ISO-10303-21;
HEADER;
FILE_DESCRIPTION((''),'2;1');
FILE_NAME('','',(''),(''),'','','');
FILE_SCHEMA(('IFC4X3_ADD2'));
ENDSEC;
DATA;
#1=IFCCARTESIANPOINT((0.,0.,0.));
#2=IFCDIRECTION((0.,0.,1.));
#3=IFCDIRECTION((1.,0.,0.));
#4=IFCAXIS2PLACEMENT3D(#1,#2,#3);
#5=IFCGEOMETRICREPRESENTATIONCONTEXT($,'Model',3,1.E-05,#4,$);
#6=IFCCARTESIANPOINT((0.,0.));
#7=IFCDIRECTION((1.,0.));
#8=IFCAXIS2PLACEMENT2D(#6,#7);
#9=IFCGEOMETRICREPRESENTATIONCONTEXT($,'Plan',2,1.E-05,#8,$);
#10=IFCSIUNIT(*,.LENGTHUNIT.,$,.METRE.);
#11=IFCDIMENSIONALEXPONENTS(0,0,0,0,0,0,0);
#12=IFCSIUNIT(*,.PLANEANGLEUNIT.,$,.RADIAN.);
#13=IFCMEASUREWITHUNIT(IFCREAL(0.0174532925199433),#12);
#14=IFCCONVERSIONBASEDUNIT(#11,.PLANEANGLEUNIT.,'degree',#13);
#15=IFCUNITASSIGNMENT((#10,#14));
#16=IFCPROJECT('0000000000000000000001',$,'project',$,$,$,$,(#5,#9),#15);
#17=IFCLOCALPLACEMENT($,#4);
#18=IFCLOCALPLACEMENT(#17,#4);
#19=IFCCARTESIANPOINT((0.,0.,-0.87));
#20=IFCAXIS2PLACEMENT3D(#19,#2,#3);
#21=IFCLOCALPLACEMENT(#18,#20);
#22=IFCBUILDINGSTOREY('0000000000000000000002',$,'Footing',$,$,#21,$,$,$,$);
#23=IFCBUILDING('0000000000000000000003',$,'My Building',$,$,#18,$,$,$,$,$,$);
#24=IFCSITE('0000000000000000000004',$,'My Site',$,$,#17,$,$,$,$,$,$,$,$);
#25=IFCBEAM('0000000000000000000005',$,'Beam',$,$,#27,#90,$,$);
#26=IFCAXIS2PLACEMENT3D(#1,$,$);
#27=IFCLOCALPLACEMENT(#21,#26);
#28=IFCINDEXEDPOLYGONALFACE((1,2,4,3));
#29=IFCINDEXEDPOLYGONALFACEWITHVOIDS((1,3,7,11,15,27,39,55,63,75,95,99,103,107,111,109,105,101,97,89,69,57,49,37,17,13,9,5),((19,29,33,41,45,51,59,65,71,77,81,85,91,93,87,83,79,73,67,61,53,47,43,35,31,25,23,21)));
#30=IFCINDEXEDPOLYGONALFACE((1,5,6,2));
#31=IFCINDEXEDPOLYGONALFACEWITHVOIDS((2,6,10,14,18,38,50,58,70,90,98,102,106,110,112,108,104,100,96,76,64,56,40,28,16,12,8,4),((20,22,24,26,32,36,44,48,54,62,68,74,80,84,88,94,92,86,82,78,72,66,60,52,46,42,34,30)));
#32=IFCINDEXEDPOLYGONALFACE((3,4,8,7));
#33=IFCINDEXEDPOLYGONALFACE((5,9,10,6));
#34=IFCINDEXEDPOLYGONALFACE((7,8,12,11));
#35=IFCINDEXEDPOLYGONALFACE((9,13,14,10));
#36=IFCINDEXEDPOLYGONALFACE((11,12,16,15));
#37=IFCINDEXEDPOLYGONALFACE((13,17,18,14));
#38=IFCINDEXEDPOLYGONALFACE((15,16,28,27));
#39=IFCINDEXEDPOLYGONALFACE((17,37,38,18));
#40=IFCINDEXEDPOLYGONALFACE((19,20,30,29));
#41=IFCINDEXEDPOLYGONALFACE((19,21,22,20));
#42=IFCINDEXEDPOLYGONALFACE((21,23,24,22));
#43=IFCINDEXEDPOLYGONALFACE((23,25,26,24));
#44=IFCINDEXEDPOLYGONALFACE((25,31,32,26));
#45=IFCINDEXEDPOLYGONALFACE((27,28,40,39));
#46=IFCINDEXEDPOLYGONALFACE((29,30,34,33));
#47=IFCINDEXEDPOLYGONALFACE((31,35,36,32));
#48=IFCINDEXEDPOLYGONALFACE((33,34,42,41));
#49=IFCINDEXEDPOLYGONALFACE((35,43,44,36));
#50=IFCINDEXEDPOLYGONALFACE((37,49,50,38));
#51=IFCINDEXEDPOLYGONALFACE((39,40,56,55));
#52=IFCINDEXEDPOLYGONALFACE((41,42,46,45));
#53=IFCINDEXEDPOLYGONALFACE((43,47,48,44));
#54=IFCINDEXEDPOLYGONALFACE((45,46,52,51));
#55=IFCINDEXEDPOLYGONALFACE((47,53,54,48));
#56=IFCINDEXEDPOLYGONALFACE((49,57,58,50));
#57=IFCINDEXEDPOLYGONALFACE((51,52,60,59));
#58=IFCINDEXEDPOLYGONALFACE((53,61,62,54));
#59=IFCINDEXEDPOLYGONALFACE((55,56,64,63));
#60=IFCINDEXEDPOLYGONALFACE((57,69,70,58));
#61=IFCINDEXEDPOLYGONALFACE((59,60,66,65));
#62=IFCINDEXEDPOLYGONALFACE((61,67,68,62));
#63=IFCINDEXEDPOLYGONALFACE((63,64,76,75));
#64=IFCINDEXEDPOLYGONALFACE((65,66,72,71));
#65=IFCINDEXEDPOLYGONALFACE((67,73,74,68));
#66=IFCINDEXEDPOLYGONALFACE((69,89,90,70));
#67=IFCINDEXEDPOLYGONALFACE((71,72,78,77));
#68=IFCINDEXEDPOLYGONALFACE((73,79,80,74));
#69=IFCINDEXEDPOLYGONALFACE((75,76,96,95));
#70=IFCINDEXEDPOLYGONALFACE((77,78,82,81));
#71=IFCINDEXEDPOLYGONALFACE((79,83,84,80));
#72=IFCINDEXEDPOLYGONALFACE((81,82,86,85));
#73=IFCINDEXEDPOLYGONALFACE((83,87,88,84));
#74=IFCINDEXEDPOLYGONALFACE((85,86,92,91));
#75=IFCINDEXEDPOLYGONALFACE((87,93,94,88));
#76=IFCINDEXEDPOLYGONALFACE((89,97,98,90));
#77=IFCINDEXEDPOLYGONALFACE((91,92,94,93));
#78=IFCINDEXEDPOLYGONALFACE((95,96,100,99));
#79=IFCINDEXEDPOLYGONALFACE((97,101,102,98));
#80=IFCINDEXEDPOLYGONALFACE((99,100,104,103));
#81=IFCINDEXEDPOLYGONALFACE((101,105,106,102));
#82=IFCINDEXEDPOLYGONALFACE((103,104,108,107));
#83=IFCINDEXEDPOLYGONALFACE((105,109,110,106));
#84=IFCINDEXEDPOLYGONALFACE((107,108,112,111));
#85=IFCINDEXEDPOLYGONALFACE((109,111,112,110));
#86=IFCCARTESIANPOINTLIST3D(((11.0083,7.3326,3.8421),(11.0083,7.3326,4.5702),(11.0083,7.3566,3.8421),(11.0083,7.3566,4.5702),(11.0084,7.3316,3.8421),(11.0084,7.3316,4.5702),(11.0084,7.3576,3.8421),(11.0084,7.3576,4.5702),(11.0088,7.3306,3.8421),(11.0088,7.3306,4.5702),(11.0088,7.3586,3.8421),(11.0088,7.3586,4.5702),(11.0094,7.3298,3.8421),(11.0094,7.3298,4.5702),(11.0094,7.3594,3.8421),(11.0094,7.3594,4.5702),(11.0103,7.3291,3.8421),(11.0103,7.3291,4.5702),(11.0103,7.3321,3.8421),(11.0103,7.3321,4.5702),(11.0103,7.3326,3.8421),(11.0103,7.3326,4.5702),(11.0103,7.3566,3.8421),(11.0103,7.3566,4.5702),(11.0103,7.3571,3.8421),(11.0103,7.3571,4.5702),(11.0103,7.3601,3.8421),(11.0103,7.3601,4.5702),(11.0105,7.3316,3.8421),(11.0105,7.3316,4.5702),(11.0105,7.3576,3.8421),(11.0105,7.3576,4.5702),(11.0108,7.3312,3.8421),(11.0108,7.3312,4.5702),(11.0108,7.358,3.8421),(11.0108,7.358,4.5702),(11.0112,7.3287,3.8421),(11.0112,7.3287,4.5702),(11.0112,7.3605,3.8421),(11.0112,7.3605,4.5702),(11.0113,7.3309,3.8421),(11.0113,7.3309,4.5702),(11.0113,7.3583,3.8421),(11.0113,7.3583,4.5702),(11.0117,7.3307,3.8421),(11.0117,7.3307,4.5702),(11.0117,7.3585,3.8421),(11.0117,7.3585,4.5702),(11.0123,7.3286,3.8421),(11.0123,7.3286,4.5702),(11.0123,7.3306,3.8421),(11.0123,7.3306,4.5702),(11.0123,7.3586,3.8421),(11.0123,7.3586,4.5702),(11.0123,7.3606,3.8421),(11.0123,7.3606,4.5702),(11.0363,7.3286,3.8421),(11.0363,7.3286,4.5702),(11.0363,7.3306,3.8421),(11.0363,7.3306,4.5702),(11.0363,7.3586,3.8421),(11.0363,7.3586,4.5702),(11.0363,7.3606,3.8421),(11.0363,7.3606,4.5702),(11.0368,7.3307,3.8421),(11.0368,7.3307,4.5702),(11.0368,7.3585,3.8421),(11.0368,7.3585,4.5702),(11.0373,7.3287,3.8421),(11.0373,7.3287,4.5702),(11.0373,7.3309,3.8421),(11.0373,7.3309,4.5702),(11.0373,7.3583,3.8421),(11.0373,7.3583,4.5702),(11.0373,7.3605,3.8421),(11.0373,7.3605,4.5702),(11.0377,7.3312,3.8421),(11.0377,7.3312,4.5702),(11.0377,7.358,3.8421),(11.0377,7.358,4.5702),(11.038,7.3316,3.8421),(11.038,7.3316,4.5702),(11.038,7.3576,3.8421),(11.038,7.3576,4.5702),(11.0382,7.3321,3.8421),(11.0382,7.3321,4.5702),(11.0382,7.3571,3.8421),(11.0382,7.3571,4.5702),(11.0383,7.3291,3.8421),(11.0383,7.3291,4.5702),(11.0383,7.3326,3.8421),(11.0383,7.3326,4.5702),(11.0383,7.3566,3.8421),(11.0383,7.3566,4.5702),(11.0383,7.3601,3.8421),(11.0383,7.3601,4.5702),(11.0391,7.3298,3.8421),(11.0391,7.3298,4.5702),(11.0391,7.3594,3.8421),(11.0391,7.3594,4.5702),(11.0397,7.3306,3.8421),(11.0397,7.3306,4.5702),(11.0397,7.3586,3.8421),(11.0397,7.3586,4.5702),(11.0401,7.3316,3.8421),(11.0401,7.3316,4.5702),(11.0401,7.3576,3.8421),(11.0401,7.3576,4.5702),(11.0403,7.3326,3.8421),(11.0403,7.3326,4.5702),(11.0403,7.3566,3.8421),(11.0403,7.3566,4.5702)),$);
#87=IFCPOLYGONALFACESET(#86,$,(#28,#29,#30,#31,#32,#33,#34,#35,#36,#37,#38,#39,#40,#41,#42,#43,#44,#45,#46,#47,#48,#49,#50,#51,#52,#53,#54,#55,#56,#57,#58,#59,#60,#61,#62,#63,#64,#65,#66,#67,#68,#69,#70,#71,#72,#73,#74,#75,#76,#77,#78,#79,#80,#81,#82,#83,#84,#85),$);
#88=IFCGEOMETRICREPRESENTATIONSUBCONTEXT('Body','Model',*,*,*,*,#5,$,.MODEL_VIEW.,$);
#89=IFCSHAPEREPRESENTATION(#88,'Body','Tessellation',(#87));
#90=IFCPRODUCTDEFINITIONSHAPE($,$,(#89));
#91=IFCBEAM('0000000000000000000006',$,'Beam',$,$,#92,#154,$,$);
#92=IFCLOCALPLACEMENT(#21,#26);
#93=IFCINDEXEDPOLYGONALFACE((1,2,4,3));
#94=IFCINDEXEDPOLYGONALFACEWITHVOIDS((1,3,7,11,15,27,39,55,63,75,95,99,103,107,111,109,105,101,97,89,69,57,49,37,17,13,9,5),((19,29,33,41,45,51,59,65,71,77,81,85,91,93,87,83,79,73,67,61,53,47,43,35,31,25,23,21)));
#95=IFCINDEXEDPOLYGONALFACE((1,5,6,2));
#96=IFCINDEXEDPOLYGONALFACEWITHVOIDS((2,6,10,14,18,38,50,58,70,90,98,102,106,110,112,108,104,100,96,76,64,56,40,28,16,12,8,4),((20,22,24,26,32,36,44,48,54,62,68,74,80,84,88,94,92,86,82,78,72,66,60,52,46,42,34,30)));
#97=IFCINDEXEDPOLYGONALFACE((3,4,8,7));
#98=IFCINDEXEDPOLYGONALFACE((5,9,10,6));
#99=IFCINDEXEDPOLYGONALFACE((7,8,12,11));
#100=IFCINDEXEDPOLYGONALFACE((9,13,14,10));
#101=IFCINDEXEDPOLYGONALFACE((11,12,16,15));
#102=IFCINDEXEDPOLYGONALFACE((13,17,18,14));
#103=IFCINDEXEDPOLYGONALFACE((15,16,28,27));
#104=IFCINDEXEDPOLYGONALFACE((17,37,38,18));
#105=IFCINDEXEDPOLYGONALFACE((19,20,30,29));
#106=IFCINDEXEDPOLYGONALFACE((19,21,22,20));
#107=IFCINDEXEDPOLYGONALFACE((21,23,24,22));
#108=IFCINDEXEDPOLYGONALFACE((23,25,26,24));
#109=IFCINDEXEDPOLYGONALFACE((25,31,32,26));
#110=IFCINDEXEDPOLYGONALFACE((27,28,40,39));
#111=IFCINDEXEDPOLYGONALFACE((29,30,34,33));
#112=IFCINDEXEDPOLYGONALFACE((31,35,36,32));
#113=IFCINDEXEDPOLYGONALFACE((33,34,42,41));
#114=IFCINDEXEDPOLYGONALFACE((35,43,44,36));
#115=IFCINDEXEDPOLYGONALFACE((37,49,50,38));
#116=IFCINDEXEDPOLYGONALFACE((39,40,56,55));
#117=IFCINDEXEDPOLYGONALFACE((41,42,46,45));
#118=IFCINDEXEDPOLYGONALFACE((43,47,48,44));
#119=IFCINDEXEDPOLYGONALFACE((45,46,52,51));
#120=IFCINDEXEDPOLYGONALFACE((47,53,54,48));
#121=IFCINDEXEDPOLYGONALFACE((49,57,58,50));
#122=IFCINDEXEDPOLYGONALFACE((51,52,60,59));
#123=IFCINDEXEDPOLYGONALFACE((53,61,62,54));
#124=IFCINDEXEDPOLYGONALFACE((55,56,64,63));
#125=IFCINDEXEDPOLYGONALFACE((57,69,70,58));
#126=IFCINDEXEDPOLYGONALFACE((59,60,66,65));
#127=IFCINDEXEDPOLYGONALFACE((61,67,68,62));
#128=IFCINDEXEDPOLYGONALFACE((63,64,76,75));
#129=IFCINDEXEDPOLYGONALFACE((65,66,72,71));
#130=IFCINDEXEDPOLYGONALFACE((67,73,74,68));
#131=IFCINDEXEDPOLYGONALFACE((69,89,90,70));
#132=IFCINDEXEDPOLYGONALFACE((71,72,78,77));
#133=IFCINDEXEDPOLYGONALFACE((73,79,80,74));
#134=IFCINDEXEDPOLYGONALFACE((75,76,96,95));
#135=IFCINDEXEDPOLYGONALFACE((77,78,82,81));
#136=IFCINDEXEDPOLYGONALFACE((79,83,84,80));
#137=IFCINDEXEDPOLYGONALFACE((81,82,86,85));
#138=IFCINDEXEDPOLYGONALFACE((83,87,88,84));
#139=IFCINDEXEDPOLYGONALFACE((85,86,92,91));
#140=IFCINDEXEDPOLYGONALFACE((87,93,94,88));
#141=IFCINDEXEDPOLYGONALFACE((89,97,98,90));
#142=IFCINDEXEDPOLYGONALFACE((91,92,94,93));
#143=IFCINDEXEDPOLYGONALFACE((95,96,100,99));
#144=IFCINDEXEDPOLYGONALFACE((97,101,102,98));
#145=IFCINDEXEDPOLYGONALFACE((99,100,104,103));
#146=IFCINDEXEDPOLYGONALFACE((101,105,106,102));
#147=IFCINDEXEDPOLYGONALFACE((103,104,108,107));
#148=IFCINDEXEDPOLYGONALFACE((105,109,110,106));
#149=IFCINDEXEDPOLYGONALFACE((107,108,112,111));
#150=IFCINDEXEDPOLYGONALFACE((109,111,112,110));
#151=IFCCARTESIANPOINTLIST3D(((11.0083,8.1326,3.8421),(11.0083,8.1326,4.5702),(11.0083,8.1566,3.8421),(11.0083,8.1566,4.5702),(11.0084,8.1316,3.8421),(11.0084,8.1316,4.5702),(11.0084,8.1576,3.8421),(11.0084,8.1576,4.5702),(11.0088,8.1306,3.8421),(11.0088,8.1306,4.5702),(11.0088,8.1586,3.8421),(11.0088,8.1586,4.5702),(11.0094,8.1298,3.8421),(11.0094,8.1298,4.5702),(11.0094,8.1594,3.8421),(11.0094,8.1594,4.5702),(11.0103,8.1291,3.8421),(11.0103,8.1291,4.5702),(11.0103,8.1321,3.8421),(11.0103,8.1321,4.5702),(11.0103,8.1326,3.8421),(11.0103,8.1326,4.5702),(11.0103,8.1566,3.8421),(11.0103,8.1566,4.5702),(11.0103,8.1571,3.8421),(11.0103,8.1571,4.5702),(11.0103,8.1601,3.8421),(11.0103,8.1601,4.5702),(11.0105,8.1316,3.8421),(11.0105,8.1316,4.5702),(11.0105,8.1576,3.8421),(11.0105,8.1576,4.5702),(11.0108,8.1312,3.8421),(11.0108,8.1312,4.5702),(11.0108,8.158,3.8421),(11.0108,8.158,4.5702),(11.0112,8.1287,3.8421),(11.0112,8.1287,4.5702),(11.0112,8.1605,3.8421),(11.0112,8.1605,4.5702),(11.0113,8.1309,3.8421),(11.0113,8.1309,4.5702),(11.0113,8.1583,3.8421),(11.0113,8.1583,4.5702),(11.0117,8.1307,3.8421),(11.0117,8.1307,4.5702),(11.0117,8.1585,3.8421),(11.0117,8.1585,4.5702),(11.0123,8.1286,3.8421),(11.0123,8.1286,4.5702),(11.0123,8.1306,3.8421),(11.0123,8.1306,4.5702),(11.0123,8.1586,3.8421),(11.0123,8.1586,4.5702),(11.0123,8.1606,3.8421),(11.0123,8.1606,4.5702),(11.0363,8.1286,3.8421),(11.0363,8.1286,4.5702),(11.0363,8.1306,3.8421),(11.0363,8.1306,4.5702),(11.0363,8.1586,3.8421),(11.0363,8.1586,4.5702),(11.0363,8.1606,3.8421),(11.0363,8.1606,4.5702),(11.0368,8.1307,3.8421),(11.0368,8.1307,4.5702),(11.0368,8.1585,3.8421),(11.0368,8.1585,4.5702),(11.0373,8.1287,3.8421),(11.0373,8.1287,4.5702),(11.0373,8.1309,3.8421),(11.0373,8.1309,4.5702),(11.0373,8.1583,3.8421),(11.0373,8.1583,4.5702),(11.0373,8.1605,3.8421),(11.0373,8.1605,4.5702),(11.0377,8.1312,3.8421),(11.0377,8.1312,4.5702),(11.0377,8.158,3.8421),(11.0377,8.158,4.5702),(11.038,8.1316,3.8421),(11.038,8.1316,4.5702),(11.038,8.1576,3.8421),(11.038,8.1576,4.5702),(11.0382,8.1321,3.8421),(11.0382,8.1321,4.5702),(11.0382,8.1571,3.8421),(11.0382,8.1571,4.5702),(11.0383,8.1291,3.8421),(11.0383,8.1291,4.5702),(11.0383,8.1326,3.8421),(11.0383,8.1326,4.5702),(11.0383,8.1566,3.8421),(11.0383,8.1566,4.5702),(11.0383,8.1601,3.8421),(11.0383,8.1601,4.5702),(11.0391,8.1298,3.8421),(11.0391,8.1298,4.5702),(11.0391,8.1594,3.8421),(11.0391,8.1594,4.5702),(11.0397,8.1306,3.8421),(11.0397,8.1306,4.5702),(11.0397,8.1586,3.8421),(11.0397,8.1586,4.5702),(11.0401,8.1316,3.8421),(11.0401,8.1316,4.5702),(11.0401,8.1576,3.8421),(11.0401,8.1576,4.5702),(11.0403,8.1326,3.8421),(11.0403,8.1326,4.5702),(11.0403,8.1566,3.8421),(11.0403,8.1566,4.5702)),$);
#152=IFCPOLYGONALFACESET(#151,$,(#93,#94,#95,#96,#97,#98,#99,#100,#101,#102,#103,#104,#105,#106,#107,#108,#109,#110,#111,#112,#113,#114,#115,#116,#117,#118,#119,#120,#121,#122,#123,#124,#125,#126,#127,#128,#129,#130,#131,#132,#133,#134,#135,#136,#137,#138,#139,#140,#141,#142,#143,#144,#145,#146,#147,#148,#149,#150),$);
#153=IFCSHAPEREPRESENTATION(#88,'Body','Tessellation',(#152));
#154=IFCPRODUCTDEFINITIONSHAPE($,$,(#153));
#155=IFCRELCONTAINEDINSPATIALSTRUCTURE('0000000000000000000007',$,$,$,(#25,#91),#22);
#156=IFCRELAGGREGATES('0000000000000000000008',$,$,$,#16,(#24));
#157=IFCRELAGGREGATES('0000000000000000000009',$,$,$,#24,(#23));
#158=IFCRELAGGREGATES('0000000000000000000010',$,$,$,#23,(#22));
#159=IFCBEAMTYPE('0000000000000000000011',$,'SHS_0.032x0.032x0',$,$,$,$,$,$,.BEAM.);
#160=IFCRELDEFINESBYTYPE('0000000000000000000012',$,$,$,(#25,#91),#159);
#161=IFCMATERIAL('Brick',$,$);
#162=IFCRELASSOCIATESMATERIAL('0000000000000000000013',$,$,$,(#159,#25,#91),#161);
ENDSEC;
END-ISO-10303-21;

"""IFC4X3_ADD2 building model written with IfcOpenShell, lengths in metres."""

from ifc_helpers import new_model, entity, si_unit, converted_unit, frame, origin_with_axes, origin_2d_with_axis, place, context, subcontext, project, spatial, hollow_rectangle, extrude, material, material_profile, profile_set, profile_usage, type_object, element, save


model = new_model("IFC4X3_ADD2")

# Units and contexts
model_context = context("Model", 3, precision=1e-05, world=origin_with_axes())
plan_context = context("Plan", 2, precision=1e-05, world=origin_2d_with_axis())
body_context = subcontext(model_context, "Body", "Model", "MODEL_VIEW")
ifc_project = project(units=[si_unit("LENGTHUNIT", "METRE"), converted_unit("PLANEANGLEUNIT", "degree", entity("IfcReal", 0.0174532925199433), si_unit("PLANEANGLEUNIT", "RADIAN"), dimensions=[0, 0, 0, 0, 0, 0, 0])], contexts=[model_context, plan_context])

# Site, building, storey
site_placement = place(None, origin_with_axes())
site = spatial("IfcSite", under=ifc_project, at=site_placement, Name="My Site")
building_placement = place(site_placement, origin_with_axes())
building = spatial("IfcBuilding", under=site, at=building_placement, Name="My Building")
storey_placement = place(building_placement, frame((0.0, 0.0, -0.87), z_axis=(0.0, 0.0, 1.0), x_axis=(1.0, 0.0, 0.0)))
storey = spatial("IfcBuildingStorey", under=building, at=storey_placement, Name="Footing")

# Beams
ifc_material_1 = material(Name="Brick")
ifc_material_profile = material_profile(ifc_material_1, hollow_rectangle(XDim=0.032, YDim=0.032, WallThickness=0.002, InnerFilletRadius=0.002, OuterFilletRadius=0.004))
ifc_profile_set = profile_set([ifc_material_profile])
beam_type_1 = type_object("IfcBeamType", Name="SHS_0.032x0.032x0", PredefinedType="BEAM", material=ifc_profile_set)
ifc_profile_usage_1 = profile_usage(ifc_profile_set, cardinal=5)
beam_1_placement = place(storey_placement, frame((11.0243, 7.3446, 3.8421), z_axis=(0.0, 0.0, 1.0), x_axis=(1.0, 0.0, 0.0)))
element("IfcBeam", 1, at=beam_1_placement, inside=storey, type_object=beam_type_1, material=ifc_profile_usage_1, Name="Beam", context=body_context, shape_type="SweptSolid", body=[
    extrude(hollow_rectangle(XDim=0.032, YDim=0.032, WallThickness=0.002, InnerFilletRadius=0.002, OuterFilletRadius=0.004), origin_with_axes(), (0.0, 0.0, 1.0), 0.7281),
])
ifc_profile_usage_2 = profile_usage(ifc_profile_set, cardinal=5)
beam_2_placement = place(storey_placement, frame((11.0243, 8.1446, 3.8421), z_axis=(0.0, 0.0, 1.0), x_axis=(1.0, 0.0, 0.0)))
element("IfcBeam", 2, at=beam_2_placement, inside=storey, type_object=beam_type_1, material=ifc_profile_usage_2, Name="Beam", context=body_context, shape_type="SweptSolid", body=[
    extrude(hollow_rectangle(XDim=0.032, YDim=0.032, WallThickness=0.002, InnerFilletRadius=0.002, OuterFilletRadius=0.004), origin_with_axes(), (0.0, 0.0, 1.0), 0.7281),
])

save(model, "model.ifc")
